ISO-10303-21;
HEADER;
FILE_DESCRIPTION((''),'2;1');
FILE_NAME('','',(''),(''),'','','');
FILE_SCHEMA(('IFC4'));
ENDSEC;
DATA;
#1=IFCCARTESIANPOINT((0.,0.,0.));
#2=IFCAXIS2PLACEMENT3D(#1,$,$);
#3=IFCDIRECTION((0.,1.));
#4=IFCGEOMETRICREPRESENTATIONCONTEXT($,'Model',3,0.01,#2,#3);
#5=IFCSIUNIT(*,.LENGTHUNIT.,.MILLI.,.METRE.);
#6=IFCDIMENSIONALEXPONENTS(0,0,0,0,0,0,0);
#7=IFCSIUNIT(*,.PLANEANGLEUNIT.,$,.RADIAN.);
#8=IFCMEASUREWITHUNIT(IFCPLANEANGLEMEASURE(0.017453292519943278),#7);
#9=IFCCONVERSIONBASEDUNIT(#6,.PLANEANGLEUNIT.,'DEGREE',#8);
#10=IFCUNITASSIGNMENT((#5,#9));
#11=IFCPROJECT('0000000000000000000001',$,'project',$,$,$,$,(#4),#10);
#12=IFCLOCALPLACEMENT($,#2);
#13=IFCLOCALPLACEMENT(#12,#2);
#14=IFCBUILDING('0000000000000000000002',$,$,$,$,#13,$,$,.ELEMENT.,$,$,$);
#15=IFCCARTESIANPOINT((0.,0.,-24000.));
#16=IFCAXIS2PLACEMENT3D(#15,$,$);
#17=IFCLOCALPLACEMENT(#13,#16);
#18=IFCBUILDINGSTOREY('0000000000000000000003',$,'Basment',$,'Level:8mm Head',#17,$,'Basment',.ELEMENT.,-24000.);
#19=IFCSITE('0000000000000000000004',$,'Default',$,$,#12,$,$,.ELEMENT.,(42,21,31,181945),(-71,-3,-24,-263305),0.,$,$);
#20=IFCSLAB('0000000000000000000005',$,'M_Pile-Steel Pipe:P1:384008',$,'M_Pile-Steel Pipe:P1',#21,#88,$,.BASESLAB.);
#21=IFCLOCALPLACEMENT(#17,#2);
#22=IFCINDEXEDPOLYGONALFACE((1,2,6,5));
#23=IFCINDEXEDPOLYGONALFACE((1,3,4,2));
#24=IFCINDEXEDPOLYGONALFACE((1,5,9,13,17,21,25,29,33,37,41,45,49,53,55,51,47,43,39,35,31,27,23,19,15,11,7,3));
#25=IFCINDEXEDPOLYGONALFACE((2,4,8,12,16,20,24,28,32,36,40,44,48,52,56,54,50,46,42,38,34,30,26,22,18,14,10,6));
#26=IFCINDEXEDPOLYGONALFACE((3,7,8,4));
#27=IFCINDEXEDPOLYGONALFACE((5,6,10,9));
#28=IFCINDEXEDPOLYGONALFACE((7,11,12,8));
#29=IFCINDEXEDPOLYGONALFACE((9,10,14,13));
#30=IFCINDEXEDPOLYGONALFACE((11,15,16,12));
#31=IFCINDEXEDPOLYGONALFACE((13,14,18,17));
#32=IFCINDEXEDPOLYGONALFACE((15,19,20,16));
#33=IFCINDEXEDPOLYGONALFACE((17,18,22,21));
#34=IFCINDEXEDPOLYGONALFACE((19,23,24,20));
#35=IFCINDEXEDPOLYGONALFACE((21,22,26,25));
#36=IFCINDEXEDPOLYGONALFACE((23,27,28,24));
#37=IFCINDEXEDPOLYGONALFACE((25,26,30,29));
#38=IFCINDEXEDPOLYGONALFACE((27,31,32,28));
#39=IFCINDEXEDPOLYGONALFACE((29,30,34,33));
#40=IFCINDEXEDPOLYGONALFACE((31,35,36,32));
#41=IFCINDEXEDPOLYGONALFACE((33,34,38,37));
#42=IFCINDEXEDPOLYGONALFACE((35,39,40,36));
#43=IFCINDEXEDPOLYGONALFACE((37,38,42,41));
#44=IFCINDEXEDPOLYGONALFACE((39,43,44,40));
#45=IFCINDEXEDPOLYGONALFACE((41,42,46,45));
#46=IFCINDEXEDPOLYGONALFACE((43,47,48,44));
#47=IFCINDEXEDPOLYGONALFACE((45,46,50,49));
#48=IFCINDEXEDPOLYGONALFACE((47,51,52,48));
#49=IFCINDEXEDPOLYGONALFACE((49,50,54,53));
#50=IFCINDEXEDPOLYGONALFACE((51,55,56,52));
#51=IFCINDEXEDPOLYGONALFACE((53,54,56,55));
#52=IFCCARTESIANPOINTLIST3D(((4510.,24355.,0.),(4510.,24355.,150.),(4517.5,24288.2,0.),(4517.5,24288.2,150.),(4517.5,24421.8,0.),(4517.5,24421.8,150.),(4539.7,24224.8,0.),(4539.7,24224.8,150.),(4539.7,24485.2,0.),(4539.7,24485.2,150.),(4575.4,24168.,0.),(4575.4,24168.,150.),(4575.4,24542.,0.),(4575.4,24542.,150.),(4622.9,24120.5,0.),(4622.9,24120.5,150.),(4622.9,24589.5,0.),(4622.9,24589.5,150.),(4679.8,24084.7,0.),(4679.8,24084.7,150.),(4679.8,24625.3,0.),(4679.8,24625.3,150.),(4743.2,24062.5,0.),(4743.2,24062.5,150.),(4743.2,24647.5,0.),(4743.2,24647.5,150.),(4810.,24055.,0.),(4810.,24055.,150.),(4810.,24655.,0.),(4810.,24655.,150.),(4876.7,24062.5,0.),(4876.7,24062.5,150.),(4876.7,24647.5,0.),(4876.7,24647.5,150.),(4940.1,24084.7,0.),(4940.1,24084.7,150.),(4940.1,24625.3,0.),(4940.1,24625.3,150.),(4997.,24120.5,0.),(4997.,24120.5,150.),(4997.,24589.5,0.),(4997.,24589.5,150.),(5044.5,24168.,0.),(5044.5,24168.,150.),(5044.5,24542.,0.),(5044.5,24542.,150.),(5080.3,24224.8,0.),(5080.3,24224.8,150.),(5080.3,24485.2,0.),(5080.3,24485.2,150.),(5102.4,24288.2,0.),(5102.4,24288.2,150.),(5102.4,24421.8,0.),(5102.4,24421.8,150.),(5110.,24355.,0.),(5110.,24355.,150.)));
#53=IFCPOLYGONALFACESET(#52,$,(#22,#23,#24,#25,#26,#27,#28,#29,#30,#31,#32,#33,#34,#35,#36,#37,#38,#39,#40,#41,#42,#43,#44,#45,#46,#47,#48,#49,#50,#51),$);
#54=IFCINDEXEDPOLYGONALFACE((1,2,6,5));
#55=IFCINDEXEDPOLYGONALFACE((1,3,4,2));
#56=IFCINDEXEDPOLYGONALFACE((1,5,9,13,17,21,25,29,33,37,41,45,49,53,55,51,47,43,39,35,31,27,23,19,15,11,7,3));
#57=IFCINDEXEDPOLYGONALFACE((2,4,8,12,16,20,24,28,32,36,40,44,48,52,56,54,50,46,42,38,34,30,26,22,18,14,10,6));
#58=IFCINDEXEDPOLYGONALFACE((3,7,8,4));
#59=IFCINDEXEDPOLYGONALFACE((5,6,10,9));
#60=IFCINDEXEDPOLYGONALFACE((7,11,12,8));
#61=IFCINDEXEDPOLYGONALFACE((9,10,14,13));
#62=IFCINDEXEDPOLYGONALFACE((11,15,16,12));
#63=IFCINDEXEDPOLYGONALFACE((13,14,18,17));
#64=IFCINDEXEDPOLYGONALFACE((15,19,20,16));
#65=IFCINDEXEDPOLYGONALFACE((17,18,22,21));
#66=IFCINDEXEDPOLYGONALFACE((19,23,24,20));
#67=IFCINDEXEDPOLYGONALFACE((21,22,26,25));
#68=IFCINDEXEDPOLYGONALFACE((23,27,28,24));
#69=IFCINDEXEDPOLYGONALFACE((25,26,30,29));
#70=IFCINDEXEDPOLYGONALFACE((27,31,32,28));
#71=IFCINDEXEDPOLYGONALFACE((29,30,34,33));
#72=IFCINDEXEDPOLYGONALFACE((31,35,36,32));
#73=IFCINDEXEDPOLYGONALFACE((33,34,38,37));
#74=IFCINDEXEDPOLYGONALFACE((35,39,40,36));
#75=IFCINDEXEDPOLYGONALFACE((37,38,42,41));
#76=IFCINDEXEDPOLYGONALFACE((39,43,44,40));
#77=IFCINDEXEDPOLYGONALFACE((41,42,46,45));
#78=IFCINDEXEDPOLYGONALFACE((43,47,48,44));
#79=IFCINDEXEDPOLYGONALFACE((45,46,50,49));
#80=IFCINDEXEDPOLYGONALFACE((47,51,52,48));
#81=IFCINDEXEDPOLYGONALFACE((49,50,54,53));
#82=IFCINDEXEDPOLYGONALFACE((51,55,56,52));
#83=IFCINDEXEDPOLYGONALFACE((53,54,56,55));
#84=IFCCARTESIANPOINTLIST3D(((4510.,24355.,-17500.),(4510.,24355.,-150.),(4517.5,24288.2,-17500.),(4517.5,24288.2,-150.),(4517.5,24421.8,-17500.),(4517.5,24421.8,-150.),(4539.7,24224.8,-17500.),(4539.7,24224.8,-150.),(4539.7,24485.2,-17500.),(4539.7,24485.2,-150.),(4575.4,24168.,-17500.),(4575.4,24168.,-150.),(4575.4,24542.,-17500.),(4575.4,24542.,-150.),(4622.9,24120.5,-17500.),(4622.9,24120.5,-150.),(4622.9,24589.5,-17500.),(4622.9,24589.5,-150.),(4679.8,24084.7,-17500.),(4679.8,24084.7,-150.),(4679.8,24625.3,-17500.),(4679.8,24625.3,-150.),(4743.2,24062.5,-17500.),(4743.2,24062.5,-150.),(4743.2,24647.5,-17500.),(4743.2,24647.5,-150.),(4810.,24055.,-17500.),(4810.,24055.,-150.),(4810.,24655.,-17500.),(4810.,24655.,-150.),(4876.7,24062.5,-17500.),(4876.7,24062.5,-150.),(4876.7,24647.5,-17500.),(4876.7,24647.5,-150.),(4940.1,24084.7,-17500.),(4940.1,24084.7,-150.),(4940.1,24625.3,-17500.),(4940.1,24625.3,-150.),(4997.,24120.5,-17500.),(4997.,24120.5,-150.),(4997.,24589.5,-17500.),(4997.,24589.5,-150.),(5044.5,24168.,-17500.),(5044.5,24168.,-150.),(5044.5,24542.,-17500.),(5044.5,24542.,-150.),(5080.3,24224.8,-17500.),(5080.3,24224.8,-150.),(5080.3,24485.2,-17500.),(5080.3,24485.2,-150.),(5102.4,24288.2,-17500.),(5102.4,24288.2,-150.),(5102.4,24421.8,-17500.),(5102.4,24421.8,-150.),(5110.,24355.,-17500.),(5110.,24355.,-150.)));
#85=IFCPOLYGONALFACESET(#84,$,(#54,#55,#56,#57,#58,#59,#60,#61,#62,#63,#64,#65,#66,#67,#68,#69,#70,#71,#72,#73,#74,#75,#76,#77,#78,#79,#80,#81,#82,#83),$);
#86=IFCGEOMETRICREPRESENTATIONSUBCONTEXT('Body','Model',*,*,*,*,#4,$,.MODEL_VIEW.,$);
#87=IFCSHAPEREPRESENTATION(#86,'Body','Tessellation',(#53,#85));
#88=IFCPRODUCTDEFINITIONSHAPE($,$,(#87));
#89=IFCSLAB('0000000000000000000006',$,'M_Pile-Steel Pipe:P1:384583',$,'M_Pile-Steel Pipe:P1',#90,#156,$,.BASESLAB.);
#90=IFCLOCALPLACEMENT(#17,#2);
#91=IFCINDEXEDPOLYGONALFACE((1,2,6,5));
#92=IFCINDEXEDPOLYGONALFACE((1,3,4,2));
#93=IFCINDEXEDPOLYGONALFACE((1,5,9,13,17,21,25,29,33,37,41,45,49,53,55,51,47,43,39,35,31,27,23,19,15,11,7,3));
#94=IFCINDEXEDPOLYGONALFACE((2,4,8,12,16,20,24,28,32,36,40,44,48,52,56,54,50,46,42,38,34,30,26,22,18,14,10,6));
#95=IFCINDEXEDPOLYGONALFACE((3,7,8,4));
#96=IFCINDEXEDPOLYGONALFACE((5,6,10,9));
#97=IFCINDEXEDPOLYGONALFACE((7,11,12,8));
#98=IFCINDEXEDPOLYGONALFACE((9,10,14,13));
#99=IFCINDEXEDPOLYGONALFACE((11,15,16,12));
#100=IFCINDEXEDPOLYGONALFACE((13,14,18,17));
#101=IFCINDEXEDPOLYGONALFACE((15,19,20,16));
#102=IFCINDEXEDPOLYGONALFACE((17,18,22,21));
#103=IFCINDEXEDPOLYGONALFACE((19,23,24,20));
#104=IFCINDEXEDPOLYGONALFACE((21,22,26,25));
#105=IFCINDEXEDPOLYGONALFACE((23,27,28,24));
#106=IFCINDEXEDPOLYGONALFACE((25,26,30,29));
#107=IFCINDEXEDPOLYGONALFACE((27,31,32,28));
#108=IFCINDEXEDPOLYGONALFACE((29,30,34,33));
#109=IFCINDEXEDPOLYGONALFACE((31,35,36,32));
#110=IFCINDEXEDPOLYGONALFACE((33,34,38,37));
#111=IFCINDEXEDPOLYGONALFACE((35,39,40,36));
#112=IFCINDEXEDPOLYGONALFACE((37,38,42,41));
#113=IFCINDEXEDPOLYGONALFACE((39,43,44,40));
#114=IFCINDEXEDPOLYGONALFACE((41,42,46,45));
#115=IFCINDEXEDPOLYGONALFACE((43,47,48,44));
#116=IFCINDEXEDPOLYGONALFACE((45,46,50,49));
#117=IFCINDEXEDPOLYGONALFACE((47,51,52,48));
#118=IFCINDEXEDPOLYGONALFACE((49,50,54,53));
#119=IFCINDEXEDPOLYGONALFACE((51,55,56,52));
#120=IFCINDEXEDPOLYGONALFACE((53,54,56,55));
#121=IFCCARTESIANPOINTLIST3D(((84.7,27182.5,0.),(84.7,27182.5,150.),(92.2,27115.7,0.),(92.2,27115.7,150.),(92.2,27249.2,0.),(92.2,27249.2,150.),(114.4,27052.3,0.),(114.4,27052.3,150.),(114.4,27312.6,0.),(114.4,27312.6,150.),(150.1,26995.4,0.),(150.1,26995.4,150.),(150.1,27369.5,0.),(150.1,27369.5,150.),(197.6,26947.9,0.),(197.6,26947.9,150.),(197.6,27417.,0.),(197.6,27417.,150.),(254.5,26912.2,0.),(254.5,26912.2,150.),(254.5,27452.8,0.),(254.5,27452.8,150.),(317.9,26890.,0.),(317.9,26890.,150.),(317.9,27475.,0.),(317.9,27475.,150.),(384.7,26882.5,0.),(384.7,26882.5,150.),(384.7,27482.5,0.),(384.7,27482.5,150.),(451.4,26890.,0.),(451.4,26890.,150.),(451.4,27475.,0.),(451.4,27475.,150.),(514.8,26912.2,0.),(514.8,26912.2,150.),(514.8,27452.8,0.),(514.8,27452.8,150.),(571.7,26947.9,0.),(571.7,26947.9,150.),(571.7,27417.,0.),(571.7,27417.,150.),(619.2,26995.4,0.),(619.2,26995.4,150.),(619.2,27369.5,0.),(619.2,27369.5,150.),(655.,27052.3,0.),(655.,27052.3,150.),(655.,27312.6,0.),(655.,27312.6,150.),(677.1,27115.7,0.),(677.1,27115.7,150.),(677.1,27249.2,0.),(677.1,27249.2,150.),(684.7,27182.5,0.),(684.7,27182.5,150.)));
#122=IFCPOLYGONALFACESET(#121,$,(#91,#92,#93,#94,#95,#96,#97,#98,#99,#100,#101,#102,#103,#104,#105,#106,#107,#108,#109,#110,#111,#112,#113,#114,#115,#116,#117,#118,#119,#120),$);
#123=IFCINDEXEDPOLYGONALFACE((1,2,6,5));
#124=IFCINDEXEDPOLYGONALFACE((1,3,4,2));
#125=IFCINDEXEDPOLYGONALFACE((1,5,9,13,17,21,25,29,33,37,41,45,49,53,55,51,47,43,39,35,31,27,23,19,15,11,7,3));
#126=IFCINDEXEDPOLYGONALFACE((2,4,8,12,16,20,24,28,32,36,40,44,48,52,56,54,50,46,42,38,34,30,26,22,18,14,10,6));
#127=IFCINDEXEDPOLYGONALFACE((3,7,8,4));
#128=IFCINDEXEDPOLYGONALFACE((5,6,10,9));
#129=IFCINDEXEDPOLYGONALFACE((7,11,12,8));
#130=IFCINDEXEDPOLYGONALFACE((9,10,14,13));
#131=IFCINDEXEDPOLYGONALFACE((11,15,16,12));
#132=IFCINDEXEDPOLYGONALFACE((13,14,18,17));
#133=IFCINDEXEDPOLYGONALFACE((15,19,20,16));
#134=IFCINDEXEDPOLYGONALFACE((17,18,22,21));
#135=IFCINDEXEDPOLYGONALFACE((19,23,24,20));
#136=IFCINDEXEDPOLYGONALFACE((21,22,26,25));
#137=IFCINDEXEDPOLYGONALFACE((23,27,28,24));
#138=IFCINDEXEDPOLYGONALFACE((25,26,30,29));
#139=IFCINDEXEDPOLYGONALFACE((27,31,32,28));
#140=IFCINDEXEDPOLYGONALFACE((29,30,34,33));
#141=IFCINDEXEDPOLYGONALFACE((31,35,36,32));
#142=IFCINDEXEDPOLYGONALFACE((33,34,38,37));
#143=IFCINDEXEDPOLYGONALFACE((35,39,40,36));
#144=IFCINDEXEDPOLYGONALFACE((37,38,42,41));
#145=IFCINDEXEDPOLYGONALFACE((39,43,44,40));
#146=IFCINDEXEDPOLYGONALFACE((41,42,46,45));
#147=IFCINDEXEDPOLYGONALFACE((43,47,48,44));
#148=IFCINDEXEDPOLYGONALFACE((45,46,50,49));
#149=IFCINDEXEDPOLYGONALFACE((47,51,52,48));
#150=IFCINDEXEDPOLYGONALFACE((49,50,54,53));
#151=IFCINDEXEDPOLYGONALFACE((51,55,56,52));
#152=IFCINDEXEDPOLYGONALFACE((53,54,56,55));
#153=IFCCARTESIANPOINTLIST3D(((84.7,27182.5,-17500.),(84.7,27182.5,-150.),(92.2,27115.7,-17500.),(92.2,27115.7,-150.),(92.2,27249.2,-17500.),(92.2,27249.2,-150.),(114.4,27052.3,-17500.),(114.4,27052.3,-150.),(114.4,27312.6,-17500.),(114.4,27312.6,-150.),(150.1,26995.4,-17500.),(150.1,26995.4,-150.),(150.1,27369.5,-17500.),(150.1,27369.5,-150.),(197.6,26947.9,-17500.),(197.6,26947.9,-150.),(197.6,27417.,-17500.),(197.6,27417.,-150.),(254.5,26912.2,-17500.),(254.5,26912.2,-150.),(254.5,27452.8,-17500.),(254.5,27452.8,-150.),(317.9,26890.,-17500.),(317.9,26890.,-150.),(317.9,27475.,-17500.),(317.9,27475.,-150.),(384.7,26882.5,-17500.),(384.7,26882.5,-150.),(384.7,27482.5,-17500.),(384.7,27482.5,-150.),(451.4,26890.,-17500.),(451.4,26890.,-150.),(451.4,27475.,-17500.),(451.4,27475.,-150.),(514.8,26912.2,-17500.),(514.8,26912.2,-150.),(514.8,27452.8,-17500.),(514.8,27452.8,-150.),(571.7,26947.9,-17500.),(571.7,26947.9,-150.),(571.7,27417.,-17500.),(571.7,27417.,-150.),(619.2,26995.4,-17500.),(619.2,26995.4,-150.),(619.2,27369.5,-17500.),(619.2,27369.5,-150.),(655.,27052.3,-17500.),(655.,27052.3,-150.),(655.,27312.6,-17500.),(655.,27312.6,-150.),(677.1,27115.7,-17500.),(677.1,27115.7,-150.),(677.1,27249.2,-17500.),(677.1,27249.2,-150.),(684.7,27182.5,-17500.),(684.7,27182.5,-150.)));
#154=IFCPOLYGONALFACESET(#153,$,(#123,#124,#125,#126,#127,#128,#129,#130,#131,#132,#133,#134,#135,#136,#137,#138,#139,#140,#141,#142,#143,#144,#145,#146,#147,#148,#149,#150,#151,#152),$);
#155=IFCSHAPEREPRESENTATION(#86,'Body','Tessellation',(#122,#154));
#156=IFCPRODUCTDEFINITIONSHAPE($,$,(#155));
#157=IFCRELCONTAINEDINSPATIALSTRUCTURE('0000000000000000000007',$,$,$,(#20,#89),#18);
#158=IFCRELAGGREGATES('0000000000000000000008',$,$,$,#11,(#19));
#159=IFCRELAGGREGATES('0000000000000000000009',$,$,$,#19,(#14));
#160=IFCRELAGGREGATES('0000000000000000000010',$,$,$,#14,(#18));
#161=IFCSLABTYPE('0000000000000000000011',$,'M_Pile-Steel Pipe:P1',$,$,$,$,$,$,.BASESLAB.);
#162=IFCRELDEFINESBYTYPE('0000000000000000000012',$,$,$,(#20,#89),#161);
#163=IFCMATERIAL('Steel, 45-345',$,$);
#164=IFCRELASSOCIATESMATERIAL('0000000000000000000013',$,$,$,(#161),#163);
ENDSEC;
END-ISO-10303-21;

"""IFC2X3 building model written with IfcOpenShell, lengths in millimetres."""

from ifc_helpers import new_model, entity, si_unit, converted_unit, direction, frame, frame_2d, origin, place, context, subcontext, project, spatial, circle, extrude, material, type_object, element, save


model = new_model("IFC2X3")

# Units and contexts
model_context = context("Model", 3, precision=0.01, world=origin(), true_north=direction((0.0, 1.0)))
body_context = subcontext(model_context, "Body", "Model", "MODEL_VIEW")
ifc_project = project(units=[si_unit("LENGTHUNIT", "METRE", prefix="MILLI"), converted_unit("PLANEANGLEUNIT", "DEGREE", entity("IfcPlaneAngleMeasure", 0.017453292519943278), si_unit("PLANEANGLEUNIT", "RADIAN"), dimensions=[0, 0, 0, 0, 0, 0, 0])], contexts=[model_context])

# Site, building, storey
site_placement = place(None, origin())
site = spatial("IfcSite", under=ifc_project, at=site_placement, Name="Default", CompositionType="ELEMENT", RefLatitude=(42, 21, 31, 181945), RefLongitude=(-71, -3, -24, -263305), RefElevation=0.0)
building_placement = place(site_placement, origin())
building = spatial("IfcBuilding", under=site, at=building_placement, CompositionType="ELEMENT")
storey_placement = place(building_placement, frame((0.0, 0.0, -24000.0)))
storey = spatial("IfcBuildingStorey", under=building, at=storey_placement, Name="Basment", ObjectType="Level:8mm Head", LongName="Basment", CompositionType="ELEMENT", Elevation=-24000.0)

# Slabs
ifc_material_1 = material(Name="Steel, 45-345")
slab_type_1 = type_object("IfcSlabType", Name="M_Pile-Steel Pipe:P1", PredefinedType="BASESLAB", material=ifc_material_1)
slab_1_placement = place(storey_placement, origin())
element("IfcSlab", 1, at=slab_1_placement, inside=storey, type_object=slab_type_1, Name="M_Pile-Steel Pipe:P1:384008", ObjectType="M_Pile-Steel Pipe:P1", PredefinedType="BASESLAB", context=body_context, shape_type="SweptSolid", body=[
    extrude(circle(Radius=300.0, at=frame_2d((0.0, 0.0), x_axis=(1.0, 0.0))), frame((4810.0, 24355.0, 0.0), z_axis=(0.0, 0.0, 1.0), x_axis=(0.0, 1.0, 0.0)), (0.0, 0.0, 1.0), 150.0),
    extrude(circle(Radius=300.0, at=frame_2d((0.0, 0.0), x_axis=(1.0, 0.0))), frame((4810.0, 24355.0, -17500.0), z_axis=(0.0, 0.0, 1.0), x_axis=(0.0, 1.0, 0.0)), (0.0, 0.0, 1.0), 17350.0),
])
slab_2_placement = place(storey_placement, origin())
element("IfcSlab", 2, at=slab_2_placement, inside=storey, type_object=slab_type_1, Name="M_Pile-Steel Pipe:P1:384583", ObjectType="M_Pile-Steel Pipe:P1", PredefinedType="BASESLAB", context=body_context, shape_type="SweptSolid", body=[
    extrude(circle(Radius=300.0, at=frame_2d((0.0, 0.0), x_axis=(1.0, 0.0))), frame((384.7, 27182.5, 0.0), z_axis=(0.0, 0.0, 1.0), x_axis=(0.0, 1.0, 0.0)), (0.0, 0.0, 1.0), 150.0),
    extrude(circle(Radius=300.0, at=frame_2d((0.0, 0.0), x_axis=(1.0, 0.0))), frame((384.7, 27182.5, -17500.0), z_axis=(0.0, 0.0, 1.0), x_axis=(0.0, 1.0, 0.0)), (0.0, 0.0, 1.0), 17350.0),
])

save(model, "model.ifc")
